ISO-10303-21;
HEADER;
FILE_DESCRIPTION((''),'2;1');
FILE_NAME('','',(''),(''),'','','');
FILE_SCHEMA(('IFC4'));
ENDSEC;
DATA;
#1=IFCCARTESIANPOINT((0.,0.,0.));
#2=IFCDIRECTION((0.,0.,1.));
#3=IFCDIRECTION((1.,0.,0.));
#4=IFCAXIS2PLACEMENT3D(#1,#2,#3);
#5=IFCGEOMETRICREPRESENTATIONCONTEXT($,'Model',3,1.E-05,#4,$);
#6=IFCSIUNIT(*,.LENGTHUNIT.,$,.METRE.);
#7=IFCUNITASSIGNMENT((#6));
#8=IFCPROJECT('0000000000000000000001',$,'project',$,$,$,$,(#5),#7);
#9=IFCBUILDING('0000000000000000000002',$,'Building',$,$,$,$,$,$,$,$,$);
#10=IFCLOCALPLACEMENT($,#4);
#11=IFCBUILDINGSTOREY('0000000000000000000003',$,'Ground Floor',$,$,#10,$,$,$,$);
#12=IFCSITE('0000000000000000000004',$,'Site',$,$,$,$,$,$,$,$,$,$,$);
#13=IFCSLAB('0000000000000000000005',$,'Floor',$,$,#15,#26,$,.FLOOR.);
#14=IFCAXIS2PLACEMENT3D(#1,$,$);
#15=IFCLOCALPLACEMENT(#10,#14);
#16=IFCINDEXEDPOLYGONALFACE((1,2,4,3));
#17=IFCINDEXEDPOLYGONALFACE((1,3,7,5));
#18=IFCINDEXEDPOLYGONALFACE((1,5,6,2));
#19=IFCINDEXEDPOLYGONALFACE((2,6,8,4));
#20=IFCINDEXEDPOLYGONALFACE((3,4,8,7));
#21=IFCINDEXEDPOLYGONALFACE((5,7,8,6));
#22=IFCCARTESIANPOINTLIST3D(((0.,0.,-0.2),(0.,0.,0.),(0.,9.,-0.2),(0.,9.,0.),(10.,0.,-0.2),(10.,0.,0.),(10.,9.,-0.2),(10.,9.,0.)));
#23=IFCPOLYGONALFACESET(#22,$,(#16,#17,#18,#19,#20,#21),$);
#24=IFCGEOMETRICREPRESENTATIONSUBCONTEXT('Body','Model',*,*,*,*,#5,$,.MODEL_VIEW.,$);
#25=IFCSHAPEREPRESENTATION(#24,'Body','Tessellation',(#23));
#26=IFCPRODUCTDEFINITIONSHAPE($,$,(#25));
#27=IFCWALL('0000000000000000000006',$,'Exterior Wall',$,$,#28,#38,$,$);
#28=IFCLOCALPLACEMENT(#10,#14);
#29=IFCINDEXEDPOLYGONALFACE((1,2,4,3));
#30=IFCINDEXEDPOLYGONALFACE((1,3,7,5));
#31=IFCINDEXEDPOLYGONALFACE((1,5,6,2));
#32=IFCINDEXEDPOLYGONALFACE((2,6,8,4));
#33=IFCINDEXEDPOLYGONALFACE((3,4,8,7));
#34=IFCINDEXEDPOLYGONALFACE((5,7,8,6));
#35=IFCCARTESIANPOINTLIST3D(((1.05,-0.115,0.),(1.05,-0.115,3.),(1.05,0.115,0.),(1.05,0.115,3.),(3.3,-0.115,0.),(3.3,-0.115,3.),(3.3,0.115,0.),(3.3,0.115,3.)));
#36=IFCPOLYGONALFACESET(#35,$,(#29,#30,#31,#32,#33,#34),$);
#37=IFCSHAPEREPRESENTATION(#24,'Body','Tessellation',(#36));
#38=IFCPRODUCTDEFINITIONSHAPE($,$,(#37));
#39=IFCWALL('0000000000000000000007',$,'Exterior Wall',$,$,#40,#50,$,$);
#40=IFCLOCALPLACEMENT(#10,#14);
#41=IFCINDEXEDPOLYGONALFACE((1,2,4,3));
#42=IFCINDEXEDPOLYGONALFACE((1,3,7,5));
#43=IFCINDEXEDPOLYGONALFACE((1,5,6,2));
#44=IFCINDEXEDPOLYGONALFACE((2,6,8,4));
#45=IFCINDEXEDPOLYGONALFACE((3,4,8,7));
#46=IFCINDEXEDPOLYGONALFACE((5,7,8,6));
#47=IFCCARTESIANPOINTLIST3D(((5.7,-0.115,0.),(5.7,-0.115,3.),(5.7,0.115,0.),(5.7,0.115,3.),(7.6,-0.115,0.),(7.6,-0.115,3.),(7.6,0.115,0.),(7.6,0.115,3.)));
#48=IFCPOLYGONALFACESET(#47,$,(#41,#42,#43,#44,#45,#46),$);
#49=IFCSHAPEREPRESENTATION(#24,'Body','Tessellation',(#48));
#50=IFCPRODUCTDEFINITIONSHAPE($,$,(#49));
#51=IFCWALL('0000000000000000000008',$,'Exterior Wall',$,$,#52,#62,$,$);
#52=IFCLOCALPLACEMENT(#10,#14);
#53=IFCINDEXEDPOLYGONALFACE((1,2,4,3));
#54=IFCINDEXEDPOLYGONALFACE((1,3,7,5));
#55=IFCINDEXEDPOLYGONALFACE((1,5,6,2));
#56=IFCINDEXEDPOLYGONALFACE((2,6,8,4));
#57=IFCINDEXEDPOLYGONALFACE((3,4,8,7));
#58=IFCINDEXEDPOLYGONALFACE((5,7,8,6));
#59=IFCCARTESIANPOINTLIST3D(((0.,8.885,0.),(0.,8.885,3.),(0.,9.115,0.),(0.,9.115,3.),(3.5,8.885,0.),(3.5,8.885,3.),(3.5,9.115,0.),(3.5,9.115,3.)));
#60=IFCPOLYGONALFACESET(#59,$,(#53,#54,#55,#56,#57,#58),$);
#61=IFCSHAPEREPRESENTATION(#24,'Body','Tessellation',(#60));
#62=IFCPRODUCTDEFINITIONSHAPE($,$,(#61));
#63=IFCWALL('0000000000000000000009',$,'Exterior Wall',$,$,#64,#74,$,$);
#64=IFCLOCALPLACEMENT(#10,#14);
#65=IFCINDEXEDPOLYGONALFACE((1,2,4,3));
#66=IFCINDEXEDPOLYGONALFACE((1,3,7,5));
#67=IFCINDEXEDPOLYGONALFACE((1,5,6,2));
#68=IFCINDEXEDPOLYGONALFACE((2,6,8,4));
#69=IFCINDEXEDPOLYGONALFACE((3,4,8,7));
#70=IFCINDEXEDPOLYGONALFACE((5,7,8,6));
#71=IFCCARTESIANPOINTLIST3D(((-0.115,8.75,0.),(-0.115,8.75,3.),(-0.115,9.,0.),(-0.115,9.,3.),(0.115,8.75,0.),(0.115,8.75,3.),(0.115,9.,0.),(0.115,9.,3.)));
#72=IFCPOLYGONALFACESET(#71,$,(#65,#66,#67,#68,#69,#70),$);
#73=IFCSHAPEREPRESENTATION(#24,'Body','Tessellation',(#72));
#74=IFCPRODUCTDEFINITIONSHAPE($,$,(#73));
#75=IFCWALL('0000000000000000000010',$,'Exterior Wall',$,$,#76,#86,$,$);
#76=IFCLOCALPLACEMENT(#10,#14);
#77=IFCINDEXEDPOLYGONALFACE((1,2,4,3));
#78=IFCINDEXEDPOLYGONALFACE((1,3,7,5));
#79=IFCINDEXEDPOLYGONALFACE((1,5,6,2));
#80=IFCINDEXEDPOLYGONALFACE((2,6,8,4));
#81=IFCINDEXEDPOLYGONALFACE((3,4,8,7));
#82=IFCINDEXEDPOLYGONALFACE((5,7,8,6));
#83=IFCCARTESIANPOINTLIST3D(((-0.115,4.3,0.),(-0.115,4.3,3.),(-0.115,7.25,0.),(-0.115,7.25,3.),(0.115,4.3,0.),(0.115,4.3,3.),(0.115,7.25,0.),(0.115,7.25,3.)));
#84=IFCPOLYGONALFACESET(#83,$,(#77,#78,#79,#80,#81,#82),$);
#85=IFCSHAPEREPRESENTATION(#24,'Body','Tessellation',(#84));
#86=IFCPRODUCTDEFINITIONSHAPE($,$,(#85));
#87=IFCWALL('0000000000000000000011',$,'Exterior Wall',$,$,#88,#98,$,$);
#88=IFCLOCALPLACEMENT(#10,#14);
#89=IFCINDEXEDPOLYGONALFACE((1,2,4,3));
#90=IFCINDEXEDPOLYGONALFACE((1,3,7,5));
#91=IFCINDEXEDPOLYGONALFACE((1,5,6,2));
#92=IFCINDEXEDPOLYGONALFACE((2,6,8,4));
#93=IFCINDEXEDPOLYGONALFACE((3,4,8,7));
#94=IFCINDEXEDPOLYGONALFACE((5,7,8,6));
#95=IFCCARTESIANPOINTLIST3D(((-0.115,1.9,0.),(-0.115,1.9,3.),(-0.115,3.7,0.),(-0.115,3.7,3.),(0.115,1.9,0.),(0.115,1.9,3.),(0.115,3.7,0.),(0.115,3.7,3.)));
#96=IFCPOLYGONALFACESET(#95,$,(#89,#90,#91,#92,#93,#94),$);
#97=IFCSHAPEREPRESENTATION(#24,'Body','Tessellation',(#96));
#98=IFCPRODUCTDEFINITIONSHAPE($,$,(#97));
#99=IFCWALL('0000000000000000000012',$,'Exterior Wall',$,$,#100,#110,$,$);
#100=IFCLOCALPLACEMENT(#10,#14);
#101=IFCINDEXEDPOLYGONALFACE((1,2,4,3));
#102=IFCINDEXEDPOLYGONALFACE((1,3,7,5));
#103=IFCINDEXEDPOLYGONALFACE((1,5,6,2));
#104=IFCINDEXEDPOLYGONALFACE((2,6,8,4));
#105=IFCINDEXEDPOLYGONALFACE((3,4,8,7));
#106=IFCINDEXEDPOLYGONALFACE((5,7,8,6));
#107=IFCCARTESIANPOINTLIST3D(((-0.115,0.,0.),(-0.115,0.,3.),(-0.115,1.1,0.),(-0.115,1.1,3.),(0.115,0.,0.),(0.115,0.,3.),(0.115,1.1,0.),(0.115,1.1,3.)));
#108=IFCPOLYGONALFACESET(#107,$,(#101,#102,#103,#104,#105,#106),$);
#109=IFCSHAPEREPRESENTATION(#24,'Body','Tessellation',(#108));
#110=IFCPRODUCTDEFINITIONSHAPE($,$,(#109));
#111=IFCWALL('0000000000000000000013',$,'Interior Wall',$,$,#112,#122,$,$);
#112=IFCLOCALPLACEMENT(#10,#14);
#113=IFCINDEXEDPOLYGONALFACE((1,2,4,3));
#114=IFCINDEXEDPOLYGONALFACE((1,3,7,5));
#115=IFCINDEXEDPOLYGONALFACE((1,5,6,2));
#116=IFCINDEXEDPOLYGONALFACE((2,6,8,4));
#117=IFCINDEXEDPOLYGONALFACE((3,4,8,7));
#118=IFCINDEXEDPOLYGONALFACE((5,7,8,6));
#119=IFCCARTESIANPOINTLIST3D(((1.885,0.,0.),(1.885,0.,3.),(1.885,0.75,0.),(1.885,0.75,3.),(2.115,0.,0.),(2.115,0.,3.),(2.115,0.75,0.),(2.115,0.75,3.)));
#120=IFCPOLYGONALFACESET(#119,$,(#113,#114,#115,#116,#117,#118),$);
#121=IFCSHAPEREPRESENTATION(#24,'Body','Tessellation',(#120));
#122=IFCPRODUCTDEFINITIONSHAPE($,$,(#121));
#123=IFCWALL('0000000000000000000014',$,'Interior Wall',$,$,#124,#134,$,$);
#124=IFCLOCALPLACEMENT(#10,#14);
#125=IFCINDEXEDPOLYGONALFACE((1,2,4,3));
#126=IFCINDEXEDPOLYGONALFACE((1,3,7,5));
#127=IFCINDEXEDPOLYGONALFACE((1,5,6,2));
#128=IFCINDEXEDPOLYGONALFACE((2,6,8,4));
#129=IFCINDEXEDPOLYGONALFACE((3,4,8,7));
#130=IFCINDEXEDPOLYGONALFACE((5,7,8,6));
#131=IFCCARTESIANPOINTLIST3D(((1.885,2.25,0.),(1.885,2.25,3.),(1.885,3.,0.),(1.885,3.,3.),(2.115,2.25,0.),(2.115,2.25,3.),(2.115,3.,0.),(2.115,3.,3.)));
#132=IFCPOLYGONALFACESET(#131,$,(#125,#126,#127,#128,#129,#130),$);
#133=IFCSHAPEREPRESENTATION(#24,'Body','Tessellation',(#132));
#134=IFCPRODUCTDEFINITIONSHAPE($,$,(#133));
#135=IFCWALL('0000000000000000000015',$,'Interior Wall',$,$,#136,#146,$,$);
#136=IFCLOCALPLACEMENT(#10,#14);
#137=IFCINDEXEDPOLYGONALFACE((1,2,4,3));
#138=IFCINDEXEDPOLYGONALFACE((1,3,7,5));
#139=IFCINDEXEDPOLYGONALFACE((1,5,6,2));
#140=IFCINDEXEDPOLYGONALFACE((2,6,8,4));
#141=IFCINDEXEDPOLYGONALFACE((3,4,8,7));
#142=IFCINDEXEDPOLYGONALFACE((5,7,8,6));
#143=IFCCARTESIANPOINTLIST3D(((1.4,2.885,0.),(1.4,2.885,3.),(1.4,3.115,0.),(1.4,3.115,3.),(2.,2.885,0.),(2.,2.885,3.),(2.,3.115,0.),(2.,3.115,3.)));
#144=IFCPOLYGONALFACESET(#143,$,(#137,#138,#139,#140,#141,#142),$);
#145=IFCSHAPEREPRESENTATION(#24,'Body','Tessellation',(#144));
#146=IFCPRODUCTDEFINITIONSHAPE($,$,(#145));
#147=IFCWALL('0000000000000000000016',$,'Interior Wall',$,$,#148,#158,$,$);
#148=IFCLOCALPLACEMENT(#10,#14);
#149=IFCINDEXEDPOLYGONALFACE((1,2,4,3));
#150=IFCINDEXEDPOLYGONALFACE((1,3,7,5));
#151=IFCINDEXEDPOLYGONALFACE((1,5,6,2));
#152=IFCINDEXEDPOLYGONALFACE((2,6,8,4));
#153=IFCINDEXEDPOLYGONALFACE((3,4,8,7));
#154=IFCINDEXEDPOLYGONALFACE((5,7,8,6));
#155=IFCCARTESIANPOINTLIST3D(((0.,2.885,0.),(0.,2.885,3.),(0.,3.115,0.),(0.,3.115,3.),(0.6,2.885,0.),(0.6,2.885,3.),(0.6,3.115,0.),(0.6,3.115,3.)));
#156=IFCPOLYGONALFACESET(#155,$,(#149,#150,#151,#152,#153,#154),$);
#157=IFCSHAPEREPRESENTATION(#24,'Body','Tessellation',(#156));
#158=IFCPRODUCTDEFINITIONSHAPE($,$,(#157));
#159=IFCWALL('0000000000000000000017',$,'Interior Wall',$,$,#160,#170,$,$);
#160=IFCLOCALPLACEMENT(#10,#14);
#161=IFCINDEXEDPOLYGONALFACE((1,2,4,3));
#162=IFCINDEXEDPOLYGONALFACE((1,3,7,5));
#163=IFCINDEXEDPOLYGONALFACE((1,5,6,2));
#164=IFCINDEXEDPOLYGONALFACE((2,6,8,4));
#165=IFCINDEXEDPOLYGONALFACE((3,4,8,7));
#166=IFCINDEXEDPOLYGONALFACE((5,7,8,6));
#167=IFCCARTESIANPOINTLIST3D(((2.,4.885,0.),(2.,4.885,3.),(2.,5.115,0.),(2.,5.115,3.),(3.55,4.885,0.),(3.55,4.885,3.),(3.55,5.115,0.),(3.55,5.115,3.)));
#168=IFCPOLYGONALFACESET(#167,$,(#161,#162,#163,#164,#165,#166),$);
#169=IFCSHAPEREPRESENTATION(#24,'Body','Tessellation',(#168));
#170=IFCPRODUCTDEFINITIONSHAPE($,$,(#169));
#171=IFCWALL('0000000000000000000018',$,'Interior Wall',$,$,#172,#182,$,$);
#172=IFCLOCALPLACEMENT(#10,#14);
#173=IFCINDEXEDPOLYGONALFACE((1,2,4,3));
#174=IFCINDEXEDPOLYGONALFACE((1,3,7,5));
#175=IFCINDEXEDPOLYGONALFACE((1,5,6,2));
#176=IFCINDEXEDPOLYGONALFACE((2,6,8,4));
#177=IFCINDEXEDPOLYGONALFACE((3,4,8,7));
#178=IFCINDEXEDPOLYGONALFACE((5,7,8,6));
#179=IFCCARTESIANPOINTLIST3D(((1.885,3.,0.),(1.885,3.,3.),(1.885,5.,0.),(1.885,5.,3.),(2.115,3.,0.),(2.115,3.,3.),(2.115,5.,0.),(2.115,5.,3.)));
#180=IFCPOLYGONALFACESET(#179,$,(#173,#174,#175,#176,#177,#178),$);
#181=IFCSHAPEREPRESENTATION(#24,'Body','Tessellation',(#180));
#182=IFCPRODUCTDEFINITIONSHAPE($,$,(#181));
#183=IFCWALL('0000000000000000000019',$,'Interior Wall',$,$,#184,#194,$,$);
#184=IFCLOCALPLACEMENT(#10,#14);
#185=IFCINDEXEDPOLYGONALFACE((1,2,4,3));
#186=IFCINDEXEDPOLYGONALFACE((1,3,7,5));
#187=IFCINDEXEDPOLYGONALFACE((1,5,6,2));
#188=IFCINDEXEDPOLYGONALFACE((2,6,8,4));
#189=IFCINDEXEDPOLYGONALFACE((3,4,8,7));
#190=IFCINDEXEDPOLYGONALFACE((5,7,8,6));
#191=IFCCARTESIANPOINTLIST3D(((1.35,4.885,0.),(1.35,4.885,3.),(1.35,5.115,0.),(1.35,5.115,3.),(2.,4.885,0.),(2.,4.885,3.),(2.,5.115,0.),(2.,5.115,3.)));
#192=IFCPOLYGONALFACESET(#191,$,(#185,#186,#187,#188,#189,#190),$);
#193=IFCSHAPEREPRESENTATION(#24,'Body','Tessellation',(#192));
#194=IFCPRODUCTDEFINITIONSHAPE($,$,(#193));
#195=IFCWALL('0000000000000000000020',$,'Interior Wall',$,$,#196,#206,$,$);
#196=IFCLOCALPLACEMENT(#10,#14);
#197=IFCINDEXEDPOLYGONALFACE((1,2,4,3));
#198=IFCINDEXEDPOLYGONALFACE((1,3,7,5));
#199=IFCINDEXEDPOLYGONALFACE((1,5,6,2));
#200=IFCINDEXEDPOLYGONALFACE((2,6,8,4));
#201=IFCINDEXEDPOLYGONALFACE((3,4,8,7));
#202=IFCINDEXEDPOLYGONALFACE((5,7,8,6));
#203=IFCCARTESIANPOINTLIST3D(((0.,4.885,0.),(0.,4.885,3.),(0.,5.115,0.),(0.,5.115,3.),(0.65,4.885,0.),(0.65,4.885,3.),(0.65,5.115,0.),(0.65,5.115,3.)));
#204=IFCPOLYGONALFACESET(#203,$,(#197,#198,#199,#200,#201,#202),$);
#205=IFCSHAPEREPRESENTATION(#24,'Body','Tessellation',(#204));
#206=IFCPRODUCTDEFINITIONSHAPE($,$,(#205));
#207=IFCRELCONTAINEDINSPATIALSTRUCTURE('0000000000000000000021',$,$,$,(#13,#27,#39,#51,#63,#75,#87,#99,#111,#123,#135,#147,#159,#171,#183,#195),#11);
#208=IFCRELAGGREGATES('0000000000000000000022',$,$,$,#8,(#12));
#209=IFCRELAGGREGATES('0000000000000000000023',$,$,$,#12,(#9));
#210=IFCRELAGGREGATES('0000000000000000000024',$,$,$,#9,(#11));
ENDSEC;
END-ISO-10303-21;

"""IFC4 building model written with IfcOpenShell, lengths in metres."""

from ifc_helpers import new_model, si_unit, frame, origin_with_axes, place, context, subcontext, project, spatial, indexed_curve, outline, extrude, element, save


model = new_model("IFC4")

# Units and contexts
model_context = context("Model", 3, precision=1e-05, world=origin_with_axes())
body_context = subcontext(model_context, "Body", "Model", "MODEL_VIEW")
ifc_project = project(units=[si_unit("LENGTHUNIT", "METRE")], contexts=[model_context])

# Site, building, storey
site = spatial("IfcSite", under=ifc_project, Name="Site")
building = spatial("IfcBuilding", under=site, Name="Building")
storey_placement = place(None, origin_with_axes())
storey = spatial("IfcBuildingStorey", under=building, at=storey_placement, Name="Ground Floor")

# Slab
slab_placement = place(storey_placement, frame((0.0, 0.0, -0.2), z_axis=(0.0, 0.0, 1.0), x_axis=(1.0, 0.0, 0.0)))
element("IfcSlab", 1, at=slab_placement, inside=storey, Name="Floor", PredefinedType="FLOOR", context=body_context, shape_type="SweptSolid", body=[
    extrude(outline(indexed_curve([(0.0, 0.0), (10.0, 0.0), (10.0, 9.0), (0.0, 9.0)])), None, (0.0, 0.0, 1.0), 0.2),
])

# Walls
wall_1_placement = place(storey_placement, frame((1.05, 0.0, 0.0), z_axis=(0.0, 0.0, 1.0), x_axis=(1.0, 0.0, 0.0)))
element("IfcWall", 2, at=wall_1_placement, inside=storey, Name="Exterior Wall", context=body_context, shape_type="SweptSolid", body=[
    extrude(outline(indexed_curve([(0.0, 0.0), (0.0, 0.23), (2.25, 0.23), (2.25, 0.0), (0.0, 0.0)], self_intersect=False)), frame((0.0, -0.115, 0.0), z_axis=(0.0, 0.0, 1.0), x_axis=(1.0, 0.0, 0.0)), (0.0, 0.0, 1.0), 3.0),
])
wall_2_placement = place(storey_placement, frame((5.7, 0.0, 0.0), z_axis=(0.0, 0.0, 1.0), x_axis=(1.0, 0.0, 0.0)))
element("IfcWall", 3, at=wall_2_placement, inside=storey, Name="Exterior Wall", context=body_context, shape_type="SweptSolid", body=[
    extrude(outline(indexed_curve([(0.0, 0.0), (0.0, 0.23), (1.9, 0.23), (1.9, 0.0), (0.0, 0.0)], self_intersect=False)), frame((0.0, -0.115, 0.0), z_axis=(0.0, 0.0, 1.0), x_axis=(1.0, 0.0, 0.0)), (0.0, 0.0, 1.0), 3.0),
])
wall_3_placement = place(storey_placement, frame((3.5, 9.0, 0.0), z_axis=(0.0, 0.0, 1.0), x_axis=(-1.0, 0.0, 0.0)))
element("IfcWall", 4, at=wall_3_placement, inside=storey, Name="Exterior Wall", context=body_context, shape_type="SweptSolid", body=[
    extrude(outline(indexed_curve([(0.0, 0.0), (0.0, 0.23), (3.5, 0.23), (3.5, 0.0), (0.0, 0.0)], self_intersect=False)), frame((0.0, -0.115, 0.0), z_axis=(0.0, 0.0, 1.0), x_axis=(1.0, 0.0, 0.0)), (0.0, 0.0, 1.0), 3.0),
])
wall_4_placement = place(storey_placement, frame((0.0, 9.0, 0.0), z_axis=(0.0, 0.0, 1.0), x_axis=(0.0, -1.0, 0.0)))
element("IfcWall", 5, at=wall_4_placement, inside=storey, Name="Exterior Wall", context=body_context, shape_type="SweptSolid", body=[
    extrude(outline(indexed_curve([(0.0, 0.0), (0.0, 0.23), (0.25, 0.23), (0.25, 0.0), (0.0, 0.0)], self_intersect=False)), frame((0.0, -0.115, 0.0), z_axis=(0.0, 0.0, 1.0), x_axis=(1.0, 0.0, 0.0)), (0.0, 0.0, 1.0), 3.0),
])
wall_5_placement = place(storey_placement, frame((0.0, 7.25, 0.0), z_axis=(0.0, 0.0, 1.0), x_axis=(0.0, -1.0, 0.0)))
element("IfcWall", 6, at=wall_5_placement, inside=storey, Name="Exterior Wall", context=body_context, shape_type="SweptSolid", body=[
    extrude(outline(indexed_curve([(0.0, 0.0), (0.0, 0.23), (2.95, 0.23), (2.95, 0.0), (0.0, 0.0)], self_intersect=False)), frame((0.0, -0.115, 0.0), z_axis=(0.0, 0.0, 1.0), x_axis=(1.0, 0.0, 0.0)), (0.0, 0.0, 1.0), 3.0),
])
wall_6_placement = place(storey_placement, frame((0.0, 3.7, 0.0), z_axis=(0.0, 0.0, 1.0), x_axis=(0.0, -1.0, 0.0)))
element("IfcWall", 7, at=wall_6_placement, inside=storey, Name="Exterior Wall", context=body_context, shape_type="SweptSolid", body=[
    extrude(outline(indexed_curve([(0.0, 0.0), (0.0, 0.23), (1.8, 0.23), (1.8, 0.0), (0.0, 0.0)], self_intersect=False)), frame((0.0, -0.115, 0.0), z_axis=(0.0, 0.0, 1.0), x_axis=(1.0, 0.0, 0.0)), (0.0, 0.0, 1.0), 3.0),
])
wall_7_placement = place(storey_placement, frame((0.0, 1.1, 0.0), z_axis=(0.0, 0.0, 1.0), x_axis=(0.0, -1.0, 0.0)))
element("IfcWall", 8, at=wall_7_placement, inside=storey, Name="Exterior Wall", context=body_context, shape_type="SweptSolid", body=[
    extrude(outline(indexed_curve([(0.0, 0.0), (0.0, 0.23), (1.1, 0.23), (1.1, 0.0), (0.0, 0.0)], self_intersect=False)), frame((0.0, -0.115, 0.0), z_axis=(0.0, 0.0, 1.0), x_axis=(1.0, 0.0, 0.0)), (0.0, 0.0, 1.0), 3.0),
])
for number, where, z_axis, x_axis, name in (
    (9, (2.0, 0.0, 0.0), (0.0, 0.0, 1.0), (0.0, 1.0, 0.0), "Interior Wall"),
    (10, (2.0, 2.25, 0.0), (0.0, 0.0, 1.0), (0.0, 1.0, 0.0), "Interior Wall"),
):
    element("IfcWall", number, at=place(storey_placement, frame(where, z_axis=z_axis, x_axis=x_axis)), inside=storey, Name=name, context=body_context, shape_type="SweptSolid", body=[
        extrude(outline(indexed_curve([(0.0, 0.0), (0.0, 0.23), (0.75, 0.23), (0.75, 0.0), (0.0, 0.0)], self_intersect=False)), frame((0.0, -0.115, 0.0), z_axis=(0.0, 0.0, 1.0), x_axis=(1.0, 0.0, 0.0)), (0.0, 0.0, 1.0), 3.0),
    ])
for number, where, z_axis, x_axis, name in (
    (11, (2.0, 3.0, 0.0), (0.0, 0.0, 1.0), (-1.0, 0.0, 0.0), "Interior Wall"),
    (12, (0.6, 3.0, 0.0), (0.0, 0.0, 1.0), (-1.0, 0.0, 0.0), "Interior Wall"),
):
    element("IfcWall", number, at=place(storey_placement, frame(where, z_axis=z_axis, x_axis=x_axis)), inside=storey, Name=name, context=body_context, shape_type="SweptSolid", body=[
        extrude(outline(indexed_curve([(0.0, 0.0), (0.0, 0.23), (0.6, 0.23), (0.6, 0.0), (0.0, 0.0)], self_intersect=False)), frame((0.0, -0.115, 0.0), z_axis=(0.0, 0.0, 1.0), x_axis=(1.0, 0.0, 0.0)), (0.0, 0.0, 1.0), 3.0),
    ])
wall_8_placement = place(storey_placement, frame((3.55, 5.0, 0.0), z_axis=(0.0, 0.0, 1.0), x_axis=(-1.0, 0.0, 0.0)))
element("IfcWall", 13, at=wall_8_placement, inside=storey, Name="Interior Wall", context=body_context, shape_type="SweptSolid", body=[
    extrude(outline(indexed_curve([(0.0, 0.0), (0.0, 0.23), (1.55, 0.23), (1.55, 0.0), (0.0, 0.0)], self_intersect=False)), frame((0.0, -0.115, 0.0), z_axis=(0.0, 0.0, 1.0), x_axis=(1.0, 0.0, 0.0)), (0.0, 0.0, 1.0), 3.0),
])
wall_9_placement = place(storey_placement, frame((2.0, 5.0, 0.0), z_axis=(0.0, 0.0, 1.0), x_axis=(0.0, -1.0, 0.0)))
element("IfcWall", 14, at=wall_9_placement, inside=storey, Name="Interior Wall", context=body_context, shape_type="SweptSolid", body=[
    extrude(outline(indexed_curve([(0.0, 0.0), (0.0, 0.23), (2.0, 0.23), (2.0, 0.0), (0.0, 0.0)], self_intersect=False)), frame((0.0, -0.115, 0.0), z_axis=(0.0, 0.0, 1.0), x_axis=(1.0, 0.0, 0.0)), (0.0, 0.0, 1.0), 3.0),
])
for number, where, z_axis, x_axis, name in (
    (15, (2.0, 5.0, 0.0), (0.0, 0.0, 1.0), (-1.0, 0.0, 0.0), "Interior Wall"),
    (16, (0.65, 5.0, 0.0), (0.0, 0.0, 1.0), (-1.0, 0.0, 0.0), "Interior Wall"),
):
    element("IfcWall", number, at=place(storey_placement, frame(where, z_axis=z_axis, x_axis=x_axis)), inside=storey, Name=name, context=body_context, shape_type="SweptSolid", body=[
        extrude(outline(indexed_curve([(0.0, 0.0), (0.0, 0.23), (0.65, 0.23), (0.65, 0.0), (0.0, 0.0)], self_intersect=False)), frame((0.0, -0.115, 0.0), z_axis=(0.0, 0.0, 1.0), x_axis=(1.0, 0.0, 0.0)), (0.0, 0.0, 1.0), 3.0),
    ])

save(model, "model.ifc")
